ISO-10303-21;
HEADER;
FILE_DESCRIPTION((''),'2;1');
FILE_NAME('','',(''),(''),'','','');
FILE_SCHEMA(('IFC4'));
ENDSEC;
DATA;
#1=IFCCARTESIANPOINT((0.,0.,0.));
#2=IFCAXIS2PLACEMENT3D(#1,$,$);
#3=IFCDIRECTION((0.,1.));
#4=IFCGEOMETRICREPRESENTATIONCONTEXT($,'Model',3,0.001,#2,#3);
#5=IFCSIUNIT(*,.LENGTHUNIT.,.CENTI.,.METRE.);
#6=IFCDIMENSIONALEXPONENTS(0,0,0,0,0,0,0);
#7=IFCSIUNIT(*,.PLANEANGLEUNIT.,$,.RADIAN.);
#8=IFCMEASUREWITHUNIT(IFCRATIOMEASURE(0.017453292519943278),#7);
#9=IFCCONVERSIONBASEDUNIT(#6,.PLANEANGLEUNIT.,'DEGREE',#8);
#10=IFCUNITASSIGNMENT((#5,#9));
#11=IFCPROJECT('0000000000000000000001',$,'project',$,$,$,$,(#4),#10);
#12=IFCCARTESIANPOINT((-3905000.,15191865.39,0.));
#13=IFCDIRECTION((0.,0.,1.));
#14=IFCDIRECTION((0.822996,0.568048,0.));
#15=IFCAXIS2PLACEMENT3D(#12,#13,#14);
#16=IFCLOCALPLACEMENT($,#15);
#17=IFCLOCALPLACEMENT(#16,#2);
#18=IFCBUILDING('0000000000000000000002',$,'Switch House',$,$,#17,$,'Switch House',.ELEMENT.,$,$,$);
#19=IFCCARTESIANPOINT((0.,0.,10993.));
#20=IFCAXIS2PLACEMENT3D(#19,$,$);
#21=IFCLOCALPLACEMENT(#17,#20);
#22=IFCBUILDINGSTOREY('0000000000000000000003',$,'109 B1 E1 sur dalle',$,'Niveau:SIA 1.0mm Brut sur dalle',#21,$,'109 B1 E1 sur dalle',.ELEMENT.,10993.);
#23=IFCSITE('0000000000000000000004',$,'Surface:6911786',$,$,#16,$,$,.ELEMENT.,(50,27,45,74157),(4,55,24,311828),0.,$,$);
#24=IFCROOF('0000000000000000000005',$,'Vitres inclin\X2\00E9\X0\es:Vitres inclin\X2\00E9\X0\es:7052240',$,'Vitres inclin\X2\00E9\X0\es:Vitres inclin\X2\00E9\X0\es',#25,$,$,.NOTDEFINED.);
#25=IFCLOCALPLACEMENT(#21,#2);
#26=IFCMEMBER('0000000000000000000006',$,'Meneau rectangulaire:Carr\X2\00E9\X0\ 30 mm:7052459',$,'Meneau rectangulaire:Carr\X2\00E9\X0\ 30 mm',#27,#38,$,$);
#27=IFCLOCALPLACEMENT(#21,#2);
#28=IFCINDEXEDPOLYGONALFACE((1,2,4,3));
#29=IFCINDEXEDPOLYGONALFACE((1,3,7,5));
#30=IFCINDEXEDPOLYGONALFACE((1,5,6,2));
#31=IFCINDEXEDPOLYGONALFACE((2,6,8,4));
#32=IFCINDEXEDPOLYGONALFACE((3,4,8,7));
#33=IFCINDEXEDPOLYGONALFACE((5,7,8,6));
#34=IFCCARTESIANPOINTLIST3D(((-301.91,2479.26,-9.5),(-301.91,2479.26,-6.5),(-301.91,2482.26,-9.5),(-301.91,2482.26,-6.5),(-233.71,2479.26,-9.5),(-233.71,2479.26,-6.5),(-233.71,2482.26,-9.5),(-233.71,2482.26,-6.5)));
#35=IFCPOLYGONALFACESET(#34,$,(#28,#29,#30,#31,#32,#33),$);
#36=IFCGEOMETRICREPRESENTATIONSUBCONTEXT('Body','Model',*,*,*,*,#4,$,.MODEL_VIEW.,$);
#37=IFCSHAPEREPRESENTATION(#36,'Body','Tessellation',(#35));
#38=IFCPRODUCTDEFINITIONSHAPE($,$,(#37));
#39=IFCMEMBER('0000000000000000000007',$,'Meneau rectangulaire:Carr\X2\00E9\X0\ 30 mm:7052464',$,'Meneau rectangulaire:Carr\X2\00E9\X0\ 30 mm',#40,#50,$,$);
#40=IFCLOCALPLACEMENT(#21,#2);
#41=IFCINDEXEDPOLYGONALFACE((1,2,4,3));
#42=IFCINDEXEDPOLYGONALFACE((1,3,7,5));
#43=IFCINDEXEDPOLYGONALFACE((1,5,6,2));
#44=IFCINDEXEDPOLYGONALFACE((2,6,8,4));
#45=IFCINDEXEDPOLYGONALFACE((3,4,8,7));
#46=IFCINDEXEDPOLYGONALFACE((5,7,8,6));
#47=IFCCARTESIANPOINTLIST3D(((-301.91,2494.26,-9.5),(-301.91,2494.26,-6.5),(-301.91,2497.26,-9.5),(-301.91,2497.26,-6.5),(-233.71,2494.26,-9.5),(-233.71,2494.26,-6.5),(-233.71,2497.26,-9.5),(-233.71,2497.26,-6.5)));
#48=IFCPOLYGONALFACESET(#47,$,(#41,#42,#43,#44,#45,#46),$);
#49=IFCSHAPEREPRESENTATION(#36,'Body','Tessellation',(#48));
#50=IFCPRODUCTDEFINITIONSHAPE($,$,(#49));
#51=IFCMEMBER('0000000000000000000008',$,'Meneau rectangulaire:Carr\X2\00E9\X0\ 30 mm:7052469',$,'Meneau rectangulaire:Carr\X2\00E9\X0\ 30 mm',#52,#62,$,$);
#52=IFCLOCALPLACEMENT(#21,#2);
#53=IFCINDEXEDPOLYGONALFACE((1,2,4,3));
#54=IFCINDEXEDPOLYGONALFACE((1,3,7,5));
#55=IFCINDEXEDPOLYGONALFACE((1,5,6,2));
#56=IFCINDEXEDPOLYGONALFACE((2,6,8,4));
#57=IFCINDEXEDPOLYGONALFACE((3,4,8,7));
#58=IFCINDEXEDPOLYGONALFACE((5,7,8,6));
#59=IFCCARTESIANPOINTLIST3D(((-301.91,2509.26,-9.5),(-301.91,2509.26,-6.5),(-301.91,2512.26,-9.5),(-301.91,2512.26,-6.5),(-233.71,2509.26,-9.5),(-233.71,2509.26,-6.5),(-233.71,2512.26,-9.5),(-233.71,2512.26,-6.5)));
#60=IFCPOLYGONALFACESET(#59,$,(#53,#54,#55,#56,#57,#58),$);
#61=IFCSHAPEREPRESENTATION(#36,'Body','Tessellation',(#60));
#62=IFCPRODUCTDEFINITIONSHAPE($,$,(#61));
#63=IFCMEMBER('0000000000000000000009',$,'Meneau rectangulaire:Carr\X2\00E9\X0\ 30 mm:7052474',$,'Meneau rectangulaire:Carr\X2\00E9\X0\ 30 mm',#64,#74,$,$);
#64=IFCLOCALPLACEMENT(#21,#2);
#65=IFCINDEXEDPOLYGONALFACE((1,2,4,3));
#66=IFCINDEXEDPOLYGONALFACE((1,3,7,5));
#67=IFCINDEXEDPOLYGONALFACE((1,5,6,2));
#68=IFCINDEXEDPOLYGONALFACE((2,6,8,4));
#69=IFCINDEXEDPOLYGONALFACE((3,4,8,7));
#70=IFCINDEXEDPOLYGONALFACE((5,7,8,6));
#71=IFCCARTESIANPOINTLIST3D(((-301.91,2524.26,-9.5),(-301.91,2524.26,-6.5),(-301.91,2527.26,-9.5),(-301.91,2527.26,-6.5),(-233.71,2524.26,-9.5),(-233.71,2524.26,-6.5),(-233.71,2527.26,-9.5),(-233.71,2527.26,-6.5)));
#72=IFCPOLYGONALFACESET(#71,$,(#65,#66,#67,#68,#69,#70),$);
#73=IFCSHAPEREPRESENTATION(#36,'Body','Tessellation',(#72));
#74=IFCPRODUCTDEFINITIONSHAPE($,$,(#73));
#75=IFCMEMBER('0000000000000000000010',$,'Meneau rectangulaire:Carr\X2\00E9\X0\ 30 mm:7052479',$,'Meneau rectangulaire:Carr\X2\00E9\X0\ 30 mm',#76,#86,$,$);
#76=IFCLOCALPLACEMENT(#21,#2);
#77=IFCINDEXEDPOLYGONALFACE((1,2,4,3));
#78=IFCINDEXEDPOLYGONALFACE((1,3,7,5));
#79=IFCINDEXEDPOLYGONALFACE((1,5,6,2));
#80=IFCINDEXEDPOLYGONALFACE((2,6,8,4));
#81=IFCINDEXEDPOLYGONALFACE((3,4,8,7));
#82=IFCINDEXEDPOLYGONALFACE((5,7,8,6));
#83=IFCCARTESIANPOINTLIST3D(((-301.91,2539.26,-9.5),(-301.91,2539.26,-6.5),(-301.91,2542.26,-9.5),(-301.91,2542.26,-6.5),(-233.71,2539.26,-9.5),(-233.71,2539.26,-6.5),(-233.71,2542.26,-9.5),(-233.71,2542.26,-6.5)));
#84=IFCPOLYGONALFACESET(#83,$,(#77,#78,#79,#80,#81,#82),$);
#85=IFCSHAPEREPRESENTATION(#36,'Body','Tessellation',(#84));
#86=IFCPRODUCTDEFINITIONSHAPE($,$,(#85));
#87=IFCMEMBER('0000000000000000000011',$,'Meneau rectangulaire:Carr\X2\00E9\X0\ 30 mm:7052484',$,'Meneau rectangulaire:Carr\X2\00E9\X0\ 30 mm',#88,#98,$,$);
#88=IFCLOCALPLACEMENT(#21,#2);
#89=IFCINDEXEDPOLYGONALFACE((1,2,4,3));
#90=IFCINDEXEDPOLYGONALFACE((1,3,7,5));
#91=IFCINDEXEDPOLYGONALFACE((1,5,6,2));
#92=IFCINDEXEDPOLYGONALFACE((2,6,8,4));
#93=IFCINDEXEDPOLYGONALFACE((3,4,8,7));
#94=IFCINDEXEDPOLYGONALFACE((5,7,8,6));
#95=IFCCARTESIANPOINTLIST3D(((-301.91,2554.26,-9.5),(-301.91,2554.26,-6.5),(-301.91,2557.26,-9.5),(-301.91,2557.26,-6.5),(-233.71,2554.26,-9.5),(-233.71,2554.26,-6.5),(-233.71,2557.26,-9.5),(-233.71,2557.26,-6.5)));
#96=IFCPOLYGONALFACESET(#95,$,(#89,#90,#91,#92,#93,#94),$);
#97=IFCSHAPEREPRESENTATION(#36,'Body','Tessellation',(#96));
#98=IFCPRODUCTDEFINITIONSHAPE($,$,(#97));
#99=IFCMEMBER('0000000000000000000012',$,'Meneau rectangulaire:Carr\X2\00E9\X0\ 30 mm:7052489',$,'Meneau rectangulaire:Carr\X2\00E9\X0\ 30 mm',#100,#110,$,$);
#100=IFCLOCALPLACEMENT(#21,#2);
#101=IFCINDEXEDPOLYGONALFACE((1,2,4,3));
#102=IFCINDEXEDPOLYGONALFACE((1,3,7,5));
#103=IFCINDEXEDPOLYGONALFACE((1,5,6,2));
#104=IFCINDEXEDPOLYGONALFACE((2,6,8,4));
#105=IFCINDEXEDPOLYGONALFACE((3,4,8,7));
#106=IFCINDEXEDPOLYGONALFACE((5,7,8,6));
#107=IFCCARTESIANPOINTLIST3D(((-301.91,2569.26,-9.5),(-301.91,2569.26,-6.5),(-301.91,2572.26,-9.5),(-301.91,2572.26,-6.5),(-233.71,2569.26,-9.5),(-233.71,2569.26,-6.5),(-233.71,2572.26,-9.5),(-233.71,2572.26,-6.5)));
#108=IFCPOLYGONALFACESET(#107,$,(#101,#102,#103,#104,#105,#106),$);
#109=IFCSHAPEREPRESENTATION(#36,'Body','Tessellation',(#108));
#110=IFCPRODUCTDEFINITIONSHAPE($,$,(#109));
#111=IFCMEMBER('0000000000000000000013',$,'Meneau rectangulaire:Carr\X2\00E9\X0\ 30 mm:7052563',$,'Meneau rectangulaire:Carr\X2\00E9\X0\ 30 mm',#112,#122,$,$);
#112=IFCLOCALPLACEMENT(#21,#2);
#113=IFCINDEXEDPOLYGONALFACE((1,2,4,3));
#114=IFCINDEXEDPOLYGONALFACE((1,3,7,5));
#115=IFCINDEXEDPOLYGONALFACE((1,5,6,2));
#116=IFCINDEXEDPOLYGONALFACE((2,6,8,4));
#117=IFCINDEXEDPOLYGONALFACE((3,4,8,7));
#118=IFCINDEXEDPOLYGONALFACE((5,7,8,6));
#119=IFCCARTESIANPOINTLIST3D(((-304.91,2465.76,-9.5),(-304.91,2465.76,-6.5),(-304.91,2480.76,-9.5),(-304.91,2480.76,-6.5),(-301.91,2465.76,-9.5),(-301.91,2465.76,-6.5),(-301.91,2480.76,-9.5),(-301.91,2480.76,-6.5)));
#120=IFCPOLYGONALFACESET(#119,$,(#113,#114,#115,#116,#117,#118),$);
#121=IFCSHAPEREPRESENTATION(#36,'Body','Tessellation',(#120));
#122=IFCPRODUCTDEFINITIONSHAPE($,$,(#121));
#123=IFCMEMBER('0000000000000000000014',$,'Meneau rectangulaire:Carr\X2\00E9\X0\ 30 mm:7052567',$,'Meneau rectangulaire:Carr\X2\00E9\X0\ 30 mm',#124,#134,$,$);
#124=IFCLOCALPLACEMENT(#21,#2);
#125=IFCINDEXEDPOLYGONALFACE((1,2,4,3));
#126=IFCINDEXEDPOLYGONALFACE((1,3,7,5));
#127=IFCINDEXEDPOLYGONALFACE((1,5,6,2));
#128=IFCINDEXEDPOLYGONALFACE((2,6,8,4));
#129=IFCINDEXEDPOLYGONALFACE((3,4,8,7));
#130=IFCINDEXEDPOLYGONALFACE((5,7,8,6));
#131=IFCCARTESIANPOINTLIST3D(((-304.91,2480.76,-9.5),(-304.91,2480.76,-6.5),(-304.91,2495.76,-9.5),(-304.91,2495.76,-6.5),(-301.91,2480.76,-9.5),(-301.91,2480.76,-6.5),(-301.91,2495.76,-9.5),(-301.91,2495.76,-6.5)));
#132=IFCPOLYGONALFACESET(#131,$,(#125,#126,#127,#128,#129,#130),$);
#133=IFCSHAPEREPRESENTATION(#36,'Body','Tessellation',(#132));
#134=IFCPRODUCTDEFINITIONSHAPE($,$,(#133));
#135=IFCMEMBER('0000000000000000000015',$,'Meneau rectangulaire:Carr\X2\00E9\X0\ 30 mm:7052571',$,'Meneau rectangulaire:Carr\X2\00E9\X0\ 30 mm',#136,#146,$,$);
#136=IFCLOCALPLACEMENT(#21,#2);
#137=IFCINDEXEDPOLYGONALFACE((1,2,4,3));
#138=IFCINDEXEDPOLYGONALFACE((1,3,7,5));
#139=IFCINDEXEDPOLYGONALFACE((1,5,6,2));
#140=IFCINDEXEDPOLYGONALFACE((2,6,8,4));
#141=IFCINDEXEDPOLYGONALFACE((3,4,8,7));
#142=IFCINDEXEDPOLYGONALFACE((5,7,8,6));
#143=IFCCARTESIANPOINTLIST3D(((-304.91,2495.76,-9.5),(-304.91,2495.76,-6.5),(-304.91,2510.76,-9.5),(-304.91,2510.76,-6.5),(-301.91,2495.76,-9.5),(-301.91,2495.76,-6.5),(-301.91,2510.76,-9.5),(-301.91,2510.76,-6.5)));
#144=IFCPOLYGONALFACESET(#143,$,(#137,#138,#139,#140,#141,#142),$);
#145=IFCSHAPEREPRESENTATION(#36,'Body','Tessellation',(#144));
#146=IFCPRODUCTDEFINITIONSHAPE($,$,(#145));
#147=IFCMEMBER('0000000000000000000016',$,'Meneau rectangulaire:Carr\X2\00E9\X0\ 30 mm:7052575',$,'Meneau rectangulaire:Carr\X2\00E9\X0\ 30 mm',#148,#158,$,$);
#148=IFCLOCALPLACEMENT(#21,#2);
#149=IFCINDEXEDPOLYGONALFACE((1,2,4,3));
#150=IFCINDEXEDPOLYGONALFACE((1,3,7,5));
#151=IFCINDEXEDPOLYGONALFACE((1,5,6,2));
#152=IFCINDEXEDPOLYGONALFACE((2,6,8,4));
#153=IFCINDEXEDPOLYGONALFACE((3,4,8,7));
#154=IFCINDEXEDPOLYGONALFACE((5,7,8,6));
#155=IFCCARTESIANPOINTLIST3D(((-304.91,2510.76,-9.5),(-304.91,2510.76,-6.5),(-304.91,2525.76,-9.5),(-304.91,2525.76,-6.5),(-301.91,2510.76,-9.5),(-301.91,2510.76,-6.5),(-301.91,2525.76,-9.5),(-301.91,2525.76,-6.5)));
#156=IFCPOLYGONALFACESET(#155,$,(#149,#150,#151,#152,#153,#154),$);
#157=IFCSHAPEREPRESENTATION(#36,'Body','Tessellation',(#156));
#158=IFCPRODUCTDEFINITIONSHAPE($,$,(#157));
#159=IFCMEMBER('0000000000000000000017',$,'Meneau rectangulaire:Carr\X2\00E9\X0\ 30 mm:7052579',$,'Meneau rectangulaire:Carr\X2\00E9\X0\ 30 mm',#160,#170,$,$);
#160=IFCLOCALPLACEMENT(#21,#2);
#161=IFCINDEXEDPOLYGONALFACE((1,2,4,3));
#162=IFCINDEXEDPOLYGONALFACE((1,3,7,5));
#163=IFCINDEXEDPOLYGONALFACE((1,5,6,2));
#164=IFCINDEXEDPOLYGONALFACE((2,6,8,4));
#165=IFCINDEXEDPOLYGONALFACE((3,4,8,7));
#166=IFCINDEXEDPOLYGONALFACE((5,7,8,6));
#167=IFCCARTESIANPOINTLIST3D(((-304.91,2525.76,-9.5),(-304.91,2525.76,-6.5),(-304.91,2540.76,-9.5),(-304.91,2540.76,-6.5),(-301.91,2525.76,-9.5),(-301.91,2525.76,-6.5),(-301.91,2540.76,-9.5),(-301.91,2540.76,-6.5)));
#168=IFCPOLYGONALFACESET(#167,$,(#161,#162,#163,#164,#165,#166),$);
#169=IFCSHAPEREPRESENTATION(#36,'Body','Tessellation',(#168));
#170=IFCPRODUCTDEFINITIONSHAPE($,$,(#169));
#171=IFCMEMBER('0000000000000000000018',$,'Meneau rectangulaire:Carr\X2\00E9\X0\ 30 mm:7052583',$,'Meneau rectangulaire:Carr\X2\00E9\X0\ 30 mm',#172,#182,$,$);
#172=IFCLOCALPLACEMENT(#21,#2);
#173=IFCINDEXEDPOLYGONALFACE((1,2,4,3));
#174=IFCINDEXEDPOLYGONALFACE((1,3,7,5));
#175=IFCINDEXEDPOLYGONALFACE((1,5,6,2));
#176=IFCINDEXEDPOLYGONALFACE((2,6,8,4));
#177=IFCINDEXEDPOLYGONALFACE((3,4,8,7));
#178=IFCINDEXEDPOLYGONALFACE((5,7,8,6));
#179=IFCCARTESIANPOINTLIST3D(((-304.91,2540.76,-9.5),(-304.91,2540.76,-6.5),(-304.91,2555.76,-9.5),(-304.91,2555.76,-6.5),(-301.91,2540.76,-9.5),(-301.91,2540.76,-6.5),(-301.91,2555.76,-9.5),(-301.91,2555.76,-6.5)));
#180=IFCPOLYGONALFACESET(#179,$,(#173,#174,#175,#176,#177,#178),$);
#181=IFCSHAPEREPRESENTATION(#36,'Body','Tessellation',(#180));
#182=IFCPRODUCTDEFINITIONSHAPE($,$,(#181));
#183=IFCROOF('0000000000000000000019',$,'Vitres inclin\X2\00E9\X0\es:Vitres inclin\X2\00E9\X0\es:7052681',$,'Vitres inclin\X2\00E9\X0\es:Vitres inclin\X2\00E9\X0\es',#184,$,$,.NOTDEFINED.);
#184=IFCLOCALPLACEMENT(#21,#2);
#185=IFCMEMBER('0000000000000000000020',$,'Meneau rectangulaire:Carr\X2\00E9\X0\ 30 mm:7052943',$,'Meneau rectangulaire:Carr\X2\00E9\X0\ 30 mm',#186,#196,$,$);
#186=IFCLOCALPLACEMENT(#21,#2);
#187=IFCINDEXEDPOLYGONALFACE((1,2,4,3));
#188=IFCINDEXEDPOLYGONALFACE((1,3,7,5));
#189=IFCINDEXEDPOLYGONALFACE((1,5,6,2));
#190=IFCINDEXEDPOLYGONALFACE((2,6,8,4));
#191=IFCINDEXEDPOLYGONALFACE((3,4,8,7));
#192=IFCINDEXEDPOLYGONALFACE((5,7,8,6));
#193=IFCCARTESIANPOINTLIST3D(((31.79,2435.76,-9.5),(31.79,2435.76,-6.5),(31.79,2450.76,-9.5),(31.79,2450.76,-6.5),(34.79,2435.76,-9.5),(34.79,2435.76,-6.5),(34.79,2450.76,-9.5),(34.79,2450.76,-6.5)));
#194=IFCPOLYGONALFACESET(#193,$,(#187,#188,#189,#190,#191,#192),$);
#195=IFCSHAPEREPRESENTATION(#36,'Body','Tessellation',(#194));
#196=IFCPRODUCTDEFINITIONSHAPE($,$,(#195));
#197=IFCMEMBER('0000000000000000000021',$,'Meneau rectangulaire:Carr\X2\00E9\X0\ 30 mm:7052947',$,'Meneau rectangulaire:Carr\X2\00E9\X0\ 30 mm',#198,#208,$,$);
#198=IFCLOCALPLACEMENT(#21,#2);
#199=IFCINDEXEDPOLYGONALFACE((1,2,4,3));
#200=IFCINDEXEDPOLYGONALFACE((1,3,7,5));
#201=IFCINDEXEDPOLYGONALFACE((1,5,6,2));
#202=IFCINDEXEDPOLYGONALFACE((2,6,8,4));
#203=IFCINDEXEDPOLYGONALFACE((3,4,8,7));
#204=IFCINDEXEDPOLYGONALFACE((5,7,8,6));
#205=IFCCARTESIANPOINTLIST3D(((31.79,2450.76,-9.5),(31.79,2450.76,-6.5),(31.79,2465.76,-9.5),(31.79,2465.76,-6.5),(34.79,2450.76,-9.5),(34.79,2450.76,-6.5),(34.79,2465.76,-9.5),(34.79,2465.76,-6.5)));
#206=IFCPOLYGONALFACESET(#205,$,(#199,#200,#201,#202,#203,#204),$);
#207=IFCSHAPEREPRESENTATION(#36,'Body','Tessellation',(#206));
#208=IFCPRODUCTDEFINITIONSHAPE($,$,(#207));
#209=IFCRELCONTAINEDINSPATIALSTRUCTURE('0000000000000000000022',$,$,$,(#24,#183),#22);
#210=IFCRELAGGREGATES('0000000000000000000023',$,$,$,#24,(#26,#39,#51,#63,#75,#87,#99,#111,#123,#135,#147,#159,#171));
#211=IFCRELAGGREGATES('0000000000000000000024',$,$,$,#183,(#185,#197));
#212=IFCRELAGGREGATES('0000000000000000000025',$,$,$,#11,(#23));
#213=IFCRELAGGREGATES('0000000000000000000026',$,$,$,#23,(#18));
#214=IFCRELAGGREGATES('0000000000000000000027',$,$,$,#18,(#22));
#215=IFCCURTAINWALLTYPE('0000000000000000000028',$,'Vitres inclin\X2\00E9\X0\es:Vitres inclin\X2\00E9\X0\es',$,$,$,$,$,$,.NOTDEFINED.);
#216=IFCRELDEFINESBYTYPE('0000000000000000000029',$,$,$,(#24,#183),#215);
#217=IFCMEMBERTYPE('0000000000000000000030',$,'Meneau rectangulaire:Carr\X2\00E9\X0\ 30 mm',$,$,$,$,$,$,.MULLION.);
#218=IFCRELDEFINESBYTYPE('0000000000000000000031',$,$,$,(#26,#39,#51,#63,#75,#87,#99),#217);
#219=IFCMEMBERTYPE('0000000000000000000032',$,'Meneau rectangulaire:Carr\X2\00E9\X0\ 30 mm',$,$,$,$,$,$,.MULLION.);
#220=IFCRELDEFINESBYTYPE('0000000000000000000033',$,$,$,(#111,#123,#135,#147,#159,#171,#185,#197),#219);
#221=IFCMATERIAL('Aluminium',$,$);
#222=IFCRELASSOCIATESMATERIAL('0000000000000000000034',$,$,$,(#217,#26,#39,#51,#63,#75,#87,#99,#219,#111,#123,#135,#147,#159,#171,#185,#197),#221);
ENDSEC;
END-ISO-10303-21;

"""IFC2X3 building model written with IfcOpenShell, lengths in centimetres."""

from ifc_helpers import new_model, entity, si_unit, converted_unit, direction, frame, origin, origin_2d_with_axis, place, context, subcontext, project, spatial, rectangle, extrude, source, transform, mapped, material, type_object, type_shapes, element, aggregate, save


model = new_model("IFC2X3")

# Units and contexts
model_context = context("Model", 3, precision=0.001, world=origin(), true_north=direction((0.0, 1.0)))
body_context = subcontext(model_context, "Body", "Model", "MODEL_VIEW")
ifc_project = project(units=[si_unit("LENGTHUNIT", "METRE", prefix="CENTI"), converted_unit("PLANEANGLEUNIT", "DEGREE", entity("IfcRatioMeasure", 0.017453292519943278), si_unit("PLANEANGLEUNIT", "RADIAN"), dimensions=[0, 0, 0, 0, 0, 0, 0])], contexts=[model_context])

# Site, building, storey
site_placement = place(None, frame((-3905000.0, 15191865.39, 0.0), z_axis=(0.0, 0.0, 1.0), x_axis=(0.822996, 0.568048, 0.0)))
site = spatial("IfcSite", under=ifc_project, at=site_placement, Name="Surface:6911786", CompositionType="ELEMENT", RefLatitude=(50, 27, 45, 74157), RefLongitude=(4, 55, 24, 311828), RefElevation=0.0)
building_placement = place(site_placement, origin())
building = spatial("IfcBuilding", under=site, at=building_placement, Name="Switch House", LongName="Switch House", CompositionType="ELEMENT")
storey_placement = place(building_placement, frame((0.0, 0.0, 10993.0)))
storey = spatial("IfcBuildingStorey", under=building, at=storey_placement, Name="109 B1 E1 sur dalle", ObjectType="Niveau:SIA 1.0mm Brut sur dalle", LongName="109 B1 E1 sur dalle", CompositionType="ELEMENT", Elevation=10993.0)

# Roofs, members
curtain_wall_type = type_object("IfcCurtainWallType", Name="Vitres inclinées:Vitres inclinées", PredefinedType="NOTDEFINED")
roof_1_placement = place(storey_placement, frame((0.0, 0.0, -10993.0)))
roof_1 = element("IfcRoof", 1, at=roof_1_placement, inside=storey, type_object=curtain_wall_type, Name="Vitres inclinées:Vitres inclinées:7052240", ObjectType="Vitres inclinées:Vitres inclinées", ShapeType="NOTDEFINED")
ifc_material = material(Name="Aluminium")
member_type_1 = type_object("IfcMemberType", Name="Meneau rectangulaire:Carré 30 mm", PredefinedType="MULLION", material=ifc_material)
shared_shape_1 = source(origin(), body_context, "Body", "SweptSolid", [
    extrude(rectangle(XDim=3.0, YDim=3.0, at=origin_2d_with_axis()), frame((0.0, 0.0, -68.2), z_axis=(0.0, 0.0, 1.0), x_axis=(0.0, -1.0, 0.0)), (0.0, 0.0, 1.0), 68.2),
])
type_shapes(member_type_1, [shared_shape_1])
member_1_placement = place(roof_1_placement, frame((-301.91, 2480.76, 10985.0), z_axis=(-1.0, 0.0, 0.0), x_axis=(0.0, 1.0, 0.0)))
member_1 = element("IfcMember", 2, at=member_1_placement, type_object=member_type_1, material=ifc_material, Name="Meneau rectangulaire:Carré 30 mm:7052459", ObjectType="Meneau rectangulaire:Carré 30 mm", context=body_context, shape_type="MappedRepresentation", body=[
    mapped(shared_shape_1, transform((0.0, 0.0, 0.0), scale=1.0)),
])
member_2_placement = place(roof_1_placement, frame((-301.91, 2495.76, 10985.0), z_axis=(-1.0, 0.0, 0.0), x_axis=(0.0, 1.0, 0.0)))
member_2 = element("IfcMember", 3, at=member_2_placement, type_object=member_type_1, material=ifc_material, Name="Meneau rectangulaire:Carré 30 mm:7052464", ObjectType="Meneau rectangulaire:Carré 30 mm", context=body_context, shape_type="MappedRepresentation", body=[
    mapped(shared_shape_1, transform((0.0, 0.0, 0.0), scale=1.0)),
])
member_3_placement = place(roof_1_placement, frame((-301.91, 2510.76, 10985.0), z_axis=(-1.0, 0.0, 0.0), x_axis=(0.0, 1.0, 0.0)))
member_3 = element("IfcMember", 4, at=member_3_placement, type_object=member_type_1, material=ifc_material, Name="Meneau rectangulaire:Carré 30 mm:7052469", ObjectType="Meneau rectangulaire:Carré 30 mm", context=body_context, shape_type="MappedRepresentation", body=[
    mapped(shared_shape_1, transform((0.0, 0.0, 0.0), scale=1.0)),
])
member_4_placement = place(roof_1_placement, frame((-301.91, 2525.76, 10985.0), z_axis=(-1.0, 0.0, 0.0), x_axis=(0.0, 1.0, 0.0)))
member_4 = element("IfcMember", 5, at=member_4_placement, type_object=member_type_1, material=ifc_material, Name="Meneau rectangulaire:Carré 30 mm:7052474", ObjectType="Meneau rectangulaire:Carré 30 mm", context=body_context, shape_type="MappedRepresentation", body=[
    mapped(shared_shape_1, transform((0.0, 0.0, 0.0), scale=1.0)),
])
member_5_placement = place(roof_1_placement, frame((-301.91, 2540.76, 10985.0), z_axis=(-1.0, 0.0, 0.0), x_axis=(0.0, 1.0, 0.0)))
member_5 = element("IfcMember", 6, at=member_5_placement, type_object=member_type_1, material=ifc_material, Name="Meneau rectangulaire:Carré 30 mm:7052479", ObjectType="Meneau rectangulaire:Carré 30 mm", context=body_context, shape_type="MappedRepresentation", body=[
    mapped(shared_shape_1, transform((0.0, 0.0, 0.0), scale=1.0)),
])
member_6_placement = place(roof_1_placement, frame((-301.91, 2555.76, 10985.0), z_axis=(-1.0, 0.0, 0.0), x_axis=(0.0, 1.0, 0.0)))
member_6 = element("IfcMember", 7, at=member_6_placement, type_object=member_type_1, material=ifc_material, Name="Meneau rectangulaire:Carré 30 mm:7052484", ObjectType="Meneau rectangulaire:Carré 30 mm", context=body_context, shape_type="MappedRepresentation", body=[
    mapped(shared_shape_1, transform((0.0, 0.0, 0.0), scale=1.0)),
])
member_7_placement = place(roof_1_placement, frame((-301.91, 2570.76, 10985.0), z_axis=(-1.0, 0.0, 0.0), x_axis=(0.0, 1.0, 0.0)))
member_7 = element("IfcMember", 8, at=member_7_placement, type_object=member_type_1, material=ifc_material, Name="Meneau rectangulaire:Carré 30 mm:7052489", ObjectType="Meneau rectangulaire:Carré 30 mm", context=body_context, shape_type="MappedRepresentation", body=[
    mapped(shared_shape_1, transform((0.0, 0.0, 0.0), scale=1.0)),
])
member_type_2 = type_object("IfcMemberType", Name="Meneau rectangulaire:Carré 30 mm", PredefinedType="MULLION", material=ifc_material)
shared_shape_2 = source(origin(), body_context, "Body", "SweptSolid", [
    extrude(rectangle(XDim=3.0, YDim=3.0, at=origin_2d_with_axis()), frame((0.0, 0.0, -15.0), z_axis=(0.0, 0.0, 1.0), x_axis=(0.0, -1.0, 0.0)), (0.0, 0.0, 1.0), 15.0),
])
type_shapes(member_type_2, [shared_shape_2])
member_8_placement = place(roof_1_placement, frame((-303.41, 2480.76, 10985.0), z_axis=(0.0, 1.0, 0.0), x_axis=(1.0, 0.0, 0.0)))
member_8 = element("IfcMember", 9, at=member_8_placement, type_object=member_type_2, material=ifc_material, Name="Meneau rectangulaire:Carré 30 mm:7052563", ObjectType="Meneau rectangulaire:Carré 30 mm", context=body_context, shape_type="MappedRepresentation", body=[
    mapped(shared_shape_2, transform((0.0, 0.0, 0.0), scale=1.0)),
])
member_9_placement = place(roof_1_placement, frame((-303.41, 2495.76, 10985.0), z_axis=(0.0, 1.0, 0.0), x_axis=(1.0, 0.0, 0.0)))
member_9 = element("IfcMember", 10, at=member_9_placement, type_object=member_type_2, material=ifc_material, Name="Meneau rectangulaire:Carré 30 mm:7052567", ObjectType="Meneau rectangulaire:Carré 30 mm", context=body_context, shape_type="MappedRepresentation", body=[
    mapped(shared_shape_2, transform((0.0, 0.0, 0.0), scale=1.0)),
])
member_10_placement = place(roof_1_placement, frame((-303.41, 2510.76, 10985.0), z_axis=(0.0, 1.0, 0.0), x_axis=(1.0, 0.0, 0.0)))
member_10 = element("IfcMember", 11, at=member_10_placement, type_object=member_type_2, material=ifc_material, Name="Meneau rectangulaire:Carré 30 mm:7052571", ObjectType="Meneau rectangulaire:Carré 30 mm", context=body_context, shape_type="MappedRepresentation", body=[
    mapped(shared_shape_2, transform((0.0, 0.0, 0.0), scale=1.0)),
])
member_11_placement = place(roof_1_placement, frame((-303.41, 2525.76, 10985.0), z_axis=(0.0, 1.0, 0.0), x_axis=(1.0, 0.0, 0.0)))
member_11 = element("IfcMember", 12, at=member_11_placement, type_object=member_type_2, material=ifc_material, Name="Meneau rectangulaire:Carré 30 mm:7052575", ObjectType="Meneau rectangulaire:Carré 30 mm", context=body_context, shape_type="MappedRepresentation", body=[
    mapped(shared_shape_2, transform((0.0, 0.0, 0.0), scale=1.0)),
])
member_12_placement = place(roof_1_placement, frame((-303.41, 2540.76, 10985.0), z_axis=(0.0, 1.0, 0.0), x_axis=(1.0, 0.0, 0.0)))
member_12 = element("IfcMember", 13, at=member_12_placement, type_object=member_type_2, material=ifc_material, Name="Meneau rectangulaire:Carré 30 mm:7052579", ObjectType="Meneau rectangulaire:Carré 30 mm", context=body_context, shape_type="MappedRepresentation", body=[
    mapped(shared_shape_2, transform((0.0, 0.0, 0.0), scale=1.0)),
])
member_13_placement = place(roof_1_placement, frame((-303.41, 2555.76, 10985.0), z_axis=(0.0, 1.0, 0.0), x_axis=(1.0, 0.0, 0.0)))
member_13 = element("IfcMember", 14, at=member_13_placement, type_object=member_type_2, material=ifc_material, Name="Meneau rectangulaire:Carré 30 mm:7052583", ObjectType="Meneau rectangulaire:Carré 30 mm", context=body_context, shape_type="MappedRepresentation", body=[
    mapped(shared_shape_2, transform((0.0, 0.0, 0.0), scale=1.0)),
])
aggregate(roof_1, [member_1, member_2, member_3, member_4, member_5, member_6, member_7, member_8, member_9, member_10, member_11, member_12, member_13])
roof_2_placement = place(storey_placement, frame((0.0, 0.0, -10993.0)))
roof_2 = element("IfcRoof", 15, at=roof_2_placement, inside=storey, type_object=curtain_wall_type, Name="Vitres inclinées:Vitres inclinées:7052681", ObjectType="Vitres inclinées:Vitres inclinées", ShapeType="NOTDEFINED")
member_14_placement = place(roof_2_placement, frame((33.29, 2450.76, 10985.0), z_axis=(0.0, 1.0, 0.0), x_axis=(1.0, 0.0, 0.0)))
member_14 = element("IfcMember", 16, at=member_14_placement, type_object=member_type_2, material=ifc_material, Name="Meneau rectangulaire:Carré 30 mm:7052943", ObjectType="Meneau rectangulaire:Carré 30 mm", context=body_context, shape_type="MappedRepresentation", body=[
    mapped(shared_shape_2, transform((0.0, 0.0, 0.0), scale=1.0)),
])
member_15_placement = place(roof_2_placement, frame((33.29, 2465.76, 10985.0), z_axis=(0.0, 1.0, 0.0), x_axis=(1.0, 0.0, 0.0)))
member_15 = element("IfcMember", 17, at=member_15_placement, type_object=member_type_2, material=ifc_material, Name="Meneau rectangulaire:Carré 30 mm:7052947", ObjectType="Meneau rectangulaire:Carré 30 mm", context=body_context, shape_type="MappedRepresentation", body=[
    mapped(shared_shape_2, transform((0.0, 0.0, 0.0), scale=1.0)),
])
aggregate(roof_2, [member_14, member_15])

save(model, "model.ifc")
